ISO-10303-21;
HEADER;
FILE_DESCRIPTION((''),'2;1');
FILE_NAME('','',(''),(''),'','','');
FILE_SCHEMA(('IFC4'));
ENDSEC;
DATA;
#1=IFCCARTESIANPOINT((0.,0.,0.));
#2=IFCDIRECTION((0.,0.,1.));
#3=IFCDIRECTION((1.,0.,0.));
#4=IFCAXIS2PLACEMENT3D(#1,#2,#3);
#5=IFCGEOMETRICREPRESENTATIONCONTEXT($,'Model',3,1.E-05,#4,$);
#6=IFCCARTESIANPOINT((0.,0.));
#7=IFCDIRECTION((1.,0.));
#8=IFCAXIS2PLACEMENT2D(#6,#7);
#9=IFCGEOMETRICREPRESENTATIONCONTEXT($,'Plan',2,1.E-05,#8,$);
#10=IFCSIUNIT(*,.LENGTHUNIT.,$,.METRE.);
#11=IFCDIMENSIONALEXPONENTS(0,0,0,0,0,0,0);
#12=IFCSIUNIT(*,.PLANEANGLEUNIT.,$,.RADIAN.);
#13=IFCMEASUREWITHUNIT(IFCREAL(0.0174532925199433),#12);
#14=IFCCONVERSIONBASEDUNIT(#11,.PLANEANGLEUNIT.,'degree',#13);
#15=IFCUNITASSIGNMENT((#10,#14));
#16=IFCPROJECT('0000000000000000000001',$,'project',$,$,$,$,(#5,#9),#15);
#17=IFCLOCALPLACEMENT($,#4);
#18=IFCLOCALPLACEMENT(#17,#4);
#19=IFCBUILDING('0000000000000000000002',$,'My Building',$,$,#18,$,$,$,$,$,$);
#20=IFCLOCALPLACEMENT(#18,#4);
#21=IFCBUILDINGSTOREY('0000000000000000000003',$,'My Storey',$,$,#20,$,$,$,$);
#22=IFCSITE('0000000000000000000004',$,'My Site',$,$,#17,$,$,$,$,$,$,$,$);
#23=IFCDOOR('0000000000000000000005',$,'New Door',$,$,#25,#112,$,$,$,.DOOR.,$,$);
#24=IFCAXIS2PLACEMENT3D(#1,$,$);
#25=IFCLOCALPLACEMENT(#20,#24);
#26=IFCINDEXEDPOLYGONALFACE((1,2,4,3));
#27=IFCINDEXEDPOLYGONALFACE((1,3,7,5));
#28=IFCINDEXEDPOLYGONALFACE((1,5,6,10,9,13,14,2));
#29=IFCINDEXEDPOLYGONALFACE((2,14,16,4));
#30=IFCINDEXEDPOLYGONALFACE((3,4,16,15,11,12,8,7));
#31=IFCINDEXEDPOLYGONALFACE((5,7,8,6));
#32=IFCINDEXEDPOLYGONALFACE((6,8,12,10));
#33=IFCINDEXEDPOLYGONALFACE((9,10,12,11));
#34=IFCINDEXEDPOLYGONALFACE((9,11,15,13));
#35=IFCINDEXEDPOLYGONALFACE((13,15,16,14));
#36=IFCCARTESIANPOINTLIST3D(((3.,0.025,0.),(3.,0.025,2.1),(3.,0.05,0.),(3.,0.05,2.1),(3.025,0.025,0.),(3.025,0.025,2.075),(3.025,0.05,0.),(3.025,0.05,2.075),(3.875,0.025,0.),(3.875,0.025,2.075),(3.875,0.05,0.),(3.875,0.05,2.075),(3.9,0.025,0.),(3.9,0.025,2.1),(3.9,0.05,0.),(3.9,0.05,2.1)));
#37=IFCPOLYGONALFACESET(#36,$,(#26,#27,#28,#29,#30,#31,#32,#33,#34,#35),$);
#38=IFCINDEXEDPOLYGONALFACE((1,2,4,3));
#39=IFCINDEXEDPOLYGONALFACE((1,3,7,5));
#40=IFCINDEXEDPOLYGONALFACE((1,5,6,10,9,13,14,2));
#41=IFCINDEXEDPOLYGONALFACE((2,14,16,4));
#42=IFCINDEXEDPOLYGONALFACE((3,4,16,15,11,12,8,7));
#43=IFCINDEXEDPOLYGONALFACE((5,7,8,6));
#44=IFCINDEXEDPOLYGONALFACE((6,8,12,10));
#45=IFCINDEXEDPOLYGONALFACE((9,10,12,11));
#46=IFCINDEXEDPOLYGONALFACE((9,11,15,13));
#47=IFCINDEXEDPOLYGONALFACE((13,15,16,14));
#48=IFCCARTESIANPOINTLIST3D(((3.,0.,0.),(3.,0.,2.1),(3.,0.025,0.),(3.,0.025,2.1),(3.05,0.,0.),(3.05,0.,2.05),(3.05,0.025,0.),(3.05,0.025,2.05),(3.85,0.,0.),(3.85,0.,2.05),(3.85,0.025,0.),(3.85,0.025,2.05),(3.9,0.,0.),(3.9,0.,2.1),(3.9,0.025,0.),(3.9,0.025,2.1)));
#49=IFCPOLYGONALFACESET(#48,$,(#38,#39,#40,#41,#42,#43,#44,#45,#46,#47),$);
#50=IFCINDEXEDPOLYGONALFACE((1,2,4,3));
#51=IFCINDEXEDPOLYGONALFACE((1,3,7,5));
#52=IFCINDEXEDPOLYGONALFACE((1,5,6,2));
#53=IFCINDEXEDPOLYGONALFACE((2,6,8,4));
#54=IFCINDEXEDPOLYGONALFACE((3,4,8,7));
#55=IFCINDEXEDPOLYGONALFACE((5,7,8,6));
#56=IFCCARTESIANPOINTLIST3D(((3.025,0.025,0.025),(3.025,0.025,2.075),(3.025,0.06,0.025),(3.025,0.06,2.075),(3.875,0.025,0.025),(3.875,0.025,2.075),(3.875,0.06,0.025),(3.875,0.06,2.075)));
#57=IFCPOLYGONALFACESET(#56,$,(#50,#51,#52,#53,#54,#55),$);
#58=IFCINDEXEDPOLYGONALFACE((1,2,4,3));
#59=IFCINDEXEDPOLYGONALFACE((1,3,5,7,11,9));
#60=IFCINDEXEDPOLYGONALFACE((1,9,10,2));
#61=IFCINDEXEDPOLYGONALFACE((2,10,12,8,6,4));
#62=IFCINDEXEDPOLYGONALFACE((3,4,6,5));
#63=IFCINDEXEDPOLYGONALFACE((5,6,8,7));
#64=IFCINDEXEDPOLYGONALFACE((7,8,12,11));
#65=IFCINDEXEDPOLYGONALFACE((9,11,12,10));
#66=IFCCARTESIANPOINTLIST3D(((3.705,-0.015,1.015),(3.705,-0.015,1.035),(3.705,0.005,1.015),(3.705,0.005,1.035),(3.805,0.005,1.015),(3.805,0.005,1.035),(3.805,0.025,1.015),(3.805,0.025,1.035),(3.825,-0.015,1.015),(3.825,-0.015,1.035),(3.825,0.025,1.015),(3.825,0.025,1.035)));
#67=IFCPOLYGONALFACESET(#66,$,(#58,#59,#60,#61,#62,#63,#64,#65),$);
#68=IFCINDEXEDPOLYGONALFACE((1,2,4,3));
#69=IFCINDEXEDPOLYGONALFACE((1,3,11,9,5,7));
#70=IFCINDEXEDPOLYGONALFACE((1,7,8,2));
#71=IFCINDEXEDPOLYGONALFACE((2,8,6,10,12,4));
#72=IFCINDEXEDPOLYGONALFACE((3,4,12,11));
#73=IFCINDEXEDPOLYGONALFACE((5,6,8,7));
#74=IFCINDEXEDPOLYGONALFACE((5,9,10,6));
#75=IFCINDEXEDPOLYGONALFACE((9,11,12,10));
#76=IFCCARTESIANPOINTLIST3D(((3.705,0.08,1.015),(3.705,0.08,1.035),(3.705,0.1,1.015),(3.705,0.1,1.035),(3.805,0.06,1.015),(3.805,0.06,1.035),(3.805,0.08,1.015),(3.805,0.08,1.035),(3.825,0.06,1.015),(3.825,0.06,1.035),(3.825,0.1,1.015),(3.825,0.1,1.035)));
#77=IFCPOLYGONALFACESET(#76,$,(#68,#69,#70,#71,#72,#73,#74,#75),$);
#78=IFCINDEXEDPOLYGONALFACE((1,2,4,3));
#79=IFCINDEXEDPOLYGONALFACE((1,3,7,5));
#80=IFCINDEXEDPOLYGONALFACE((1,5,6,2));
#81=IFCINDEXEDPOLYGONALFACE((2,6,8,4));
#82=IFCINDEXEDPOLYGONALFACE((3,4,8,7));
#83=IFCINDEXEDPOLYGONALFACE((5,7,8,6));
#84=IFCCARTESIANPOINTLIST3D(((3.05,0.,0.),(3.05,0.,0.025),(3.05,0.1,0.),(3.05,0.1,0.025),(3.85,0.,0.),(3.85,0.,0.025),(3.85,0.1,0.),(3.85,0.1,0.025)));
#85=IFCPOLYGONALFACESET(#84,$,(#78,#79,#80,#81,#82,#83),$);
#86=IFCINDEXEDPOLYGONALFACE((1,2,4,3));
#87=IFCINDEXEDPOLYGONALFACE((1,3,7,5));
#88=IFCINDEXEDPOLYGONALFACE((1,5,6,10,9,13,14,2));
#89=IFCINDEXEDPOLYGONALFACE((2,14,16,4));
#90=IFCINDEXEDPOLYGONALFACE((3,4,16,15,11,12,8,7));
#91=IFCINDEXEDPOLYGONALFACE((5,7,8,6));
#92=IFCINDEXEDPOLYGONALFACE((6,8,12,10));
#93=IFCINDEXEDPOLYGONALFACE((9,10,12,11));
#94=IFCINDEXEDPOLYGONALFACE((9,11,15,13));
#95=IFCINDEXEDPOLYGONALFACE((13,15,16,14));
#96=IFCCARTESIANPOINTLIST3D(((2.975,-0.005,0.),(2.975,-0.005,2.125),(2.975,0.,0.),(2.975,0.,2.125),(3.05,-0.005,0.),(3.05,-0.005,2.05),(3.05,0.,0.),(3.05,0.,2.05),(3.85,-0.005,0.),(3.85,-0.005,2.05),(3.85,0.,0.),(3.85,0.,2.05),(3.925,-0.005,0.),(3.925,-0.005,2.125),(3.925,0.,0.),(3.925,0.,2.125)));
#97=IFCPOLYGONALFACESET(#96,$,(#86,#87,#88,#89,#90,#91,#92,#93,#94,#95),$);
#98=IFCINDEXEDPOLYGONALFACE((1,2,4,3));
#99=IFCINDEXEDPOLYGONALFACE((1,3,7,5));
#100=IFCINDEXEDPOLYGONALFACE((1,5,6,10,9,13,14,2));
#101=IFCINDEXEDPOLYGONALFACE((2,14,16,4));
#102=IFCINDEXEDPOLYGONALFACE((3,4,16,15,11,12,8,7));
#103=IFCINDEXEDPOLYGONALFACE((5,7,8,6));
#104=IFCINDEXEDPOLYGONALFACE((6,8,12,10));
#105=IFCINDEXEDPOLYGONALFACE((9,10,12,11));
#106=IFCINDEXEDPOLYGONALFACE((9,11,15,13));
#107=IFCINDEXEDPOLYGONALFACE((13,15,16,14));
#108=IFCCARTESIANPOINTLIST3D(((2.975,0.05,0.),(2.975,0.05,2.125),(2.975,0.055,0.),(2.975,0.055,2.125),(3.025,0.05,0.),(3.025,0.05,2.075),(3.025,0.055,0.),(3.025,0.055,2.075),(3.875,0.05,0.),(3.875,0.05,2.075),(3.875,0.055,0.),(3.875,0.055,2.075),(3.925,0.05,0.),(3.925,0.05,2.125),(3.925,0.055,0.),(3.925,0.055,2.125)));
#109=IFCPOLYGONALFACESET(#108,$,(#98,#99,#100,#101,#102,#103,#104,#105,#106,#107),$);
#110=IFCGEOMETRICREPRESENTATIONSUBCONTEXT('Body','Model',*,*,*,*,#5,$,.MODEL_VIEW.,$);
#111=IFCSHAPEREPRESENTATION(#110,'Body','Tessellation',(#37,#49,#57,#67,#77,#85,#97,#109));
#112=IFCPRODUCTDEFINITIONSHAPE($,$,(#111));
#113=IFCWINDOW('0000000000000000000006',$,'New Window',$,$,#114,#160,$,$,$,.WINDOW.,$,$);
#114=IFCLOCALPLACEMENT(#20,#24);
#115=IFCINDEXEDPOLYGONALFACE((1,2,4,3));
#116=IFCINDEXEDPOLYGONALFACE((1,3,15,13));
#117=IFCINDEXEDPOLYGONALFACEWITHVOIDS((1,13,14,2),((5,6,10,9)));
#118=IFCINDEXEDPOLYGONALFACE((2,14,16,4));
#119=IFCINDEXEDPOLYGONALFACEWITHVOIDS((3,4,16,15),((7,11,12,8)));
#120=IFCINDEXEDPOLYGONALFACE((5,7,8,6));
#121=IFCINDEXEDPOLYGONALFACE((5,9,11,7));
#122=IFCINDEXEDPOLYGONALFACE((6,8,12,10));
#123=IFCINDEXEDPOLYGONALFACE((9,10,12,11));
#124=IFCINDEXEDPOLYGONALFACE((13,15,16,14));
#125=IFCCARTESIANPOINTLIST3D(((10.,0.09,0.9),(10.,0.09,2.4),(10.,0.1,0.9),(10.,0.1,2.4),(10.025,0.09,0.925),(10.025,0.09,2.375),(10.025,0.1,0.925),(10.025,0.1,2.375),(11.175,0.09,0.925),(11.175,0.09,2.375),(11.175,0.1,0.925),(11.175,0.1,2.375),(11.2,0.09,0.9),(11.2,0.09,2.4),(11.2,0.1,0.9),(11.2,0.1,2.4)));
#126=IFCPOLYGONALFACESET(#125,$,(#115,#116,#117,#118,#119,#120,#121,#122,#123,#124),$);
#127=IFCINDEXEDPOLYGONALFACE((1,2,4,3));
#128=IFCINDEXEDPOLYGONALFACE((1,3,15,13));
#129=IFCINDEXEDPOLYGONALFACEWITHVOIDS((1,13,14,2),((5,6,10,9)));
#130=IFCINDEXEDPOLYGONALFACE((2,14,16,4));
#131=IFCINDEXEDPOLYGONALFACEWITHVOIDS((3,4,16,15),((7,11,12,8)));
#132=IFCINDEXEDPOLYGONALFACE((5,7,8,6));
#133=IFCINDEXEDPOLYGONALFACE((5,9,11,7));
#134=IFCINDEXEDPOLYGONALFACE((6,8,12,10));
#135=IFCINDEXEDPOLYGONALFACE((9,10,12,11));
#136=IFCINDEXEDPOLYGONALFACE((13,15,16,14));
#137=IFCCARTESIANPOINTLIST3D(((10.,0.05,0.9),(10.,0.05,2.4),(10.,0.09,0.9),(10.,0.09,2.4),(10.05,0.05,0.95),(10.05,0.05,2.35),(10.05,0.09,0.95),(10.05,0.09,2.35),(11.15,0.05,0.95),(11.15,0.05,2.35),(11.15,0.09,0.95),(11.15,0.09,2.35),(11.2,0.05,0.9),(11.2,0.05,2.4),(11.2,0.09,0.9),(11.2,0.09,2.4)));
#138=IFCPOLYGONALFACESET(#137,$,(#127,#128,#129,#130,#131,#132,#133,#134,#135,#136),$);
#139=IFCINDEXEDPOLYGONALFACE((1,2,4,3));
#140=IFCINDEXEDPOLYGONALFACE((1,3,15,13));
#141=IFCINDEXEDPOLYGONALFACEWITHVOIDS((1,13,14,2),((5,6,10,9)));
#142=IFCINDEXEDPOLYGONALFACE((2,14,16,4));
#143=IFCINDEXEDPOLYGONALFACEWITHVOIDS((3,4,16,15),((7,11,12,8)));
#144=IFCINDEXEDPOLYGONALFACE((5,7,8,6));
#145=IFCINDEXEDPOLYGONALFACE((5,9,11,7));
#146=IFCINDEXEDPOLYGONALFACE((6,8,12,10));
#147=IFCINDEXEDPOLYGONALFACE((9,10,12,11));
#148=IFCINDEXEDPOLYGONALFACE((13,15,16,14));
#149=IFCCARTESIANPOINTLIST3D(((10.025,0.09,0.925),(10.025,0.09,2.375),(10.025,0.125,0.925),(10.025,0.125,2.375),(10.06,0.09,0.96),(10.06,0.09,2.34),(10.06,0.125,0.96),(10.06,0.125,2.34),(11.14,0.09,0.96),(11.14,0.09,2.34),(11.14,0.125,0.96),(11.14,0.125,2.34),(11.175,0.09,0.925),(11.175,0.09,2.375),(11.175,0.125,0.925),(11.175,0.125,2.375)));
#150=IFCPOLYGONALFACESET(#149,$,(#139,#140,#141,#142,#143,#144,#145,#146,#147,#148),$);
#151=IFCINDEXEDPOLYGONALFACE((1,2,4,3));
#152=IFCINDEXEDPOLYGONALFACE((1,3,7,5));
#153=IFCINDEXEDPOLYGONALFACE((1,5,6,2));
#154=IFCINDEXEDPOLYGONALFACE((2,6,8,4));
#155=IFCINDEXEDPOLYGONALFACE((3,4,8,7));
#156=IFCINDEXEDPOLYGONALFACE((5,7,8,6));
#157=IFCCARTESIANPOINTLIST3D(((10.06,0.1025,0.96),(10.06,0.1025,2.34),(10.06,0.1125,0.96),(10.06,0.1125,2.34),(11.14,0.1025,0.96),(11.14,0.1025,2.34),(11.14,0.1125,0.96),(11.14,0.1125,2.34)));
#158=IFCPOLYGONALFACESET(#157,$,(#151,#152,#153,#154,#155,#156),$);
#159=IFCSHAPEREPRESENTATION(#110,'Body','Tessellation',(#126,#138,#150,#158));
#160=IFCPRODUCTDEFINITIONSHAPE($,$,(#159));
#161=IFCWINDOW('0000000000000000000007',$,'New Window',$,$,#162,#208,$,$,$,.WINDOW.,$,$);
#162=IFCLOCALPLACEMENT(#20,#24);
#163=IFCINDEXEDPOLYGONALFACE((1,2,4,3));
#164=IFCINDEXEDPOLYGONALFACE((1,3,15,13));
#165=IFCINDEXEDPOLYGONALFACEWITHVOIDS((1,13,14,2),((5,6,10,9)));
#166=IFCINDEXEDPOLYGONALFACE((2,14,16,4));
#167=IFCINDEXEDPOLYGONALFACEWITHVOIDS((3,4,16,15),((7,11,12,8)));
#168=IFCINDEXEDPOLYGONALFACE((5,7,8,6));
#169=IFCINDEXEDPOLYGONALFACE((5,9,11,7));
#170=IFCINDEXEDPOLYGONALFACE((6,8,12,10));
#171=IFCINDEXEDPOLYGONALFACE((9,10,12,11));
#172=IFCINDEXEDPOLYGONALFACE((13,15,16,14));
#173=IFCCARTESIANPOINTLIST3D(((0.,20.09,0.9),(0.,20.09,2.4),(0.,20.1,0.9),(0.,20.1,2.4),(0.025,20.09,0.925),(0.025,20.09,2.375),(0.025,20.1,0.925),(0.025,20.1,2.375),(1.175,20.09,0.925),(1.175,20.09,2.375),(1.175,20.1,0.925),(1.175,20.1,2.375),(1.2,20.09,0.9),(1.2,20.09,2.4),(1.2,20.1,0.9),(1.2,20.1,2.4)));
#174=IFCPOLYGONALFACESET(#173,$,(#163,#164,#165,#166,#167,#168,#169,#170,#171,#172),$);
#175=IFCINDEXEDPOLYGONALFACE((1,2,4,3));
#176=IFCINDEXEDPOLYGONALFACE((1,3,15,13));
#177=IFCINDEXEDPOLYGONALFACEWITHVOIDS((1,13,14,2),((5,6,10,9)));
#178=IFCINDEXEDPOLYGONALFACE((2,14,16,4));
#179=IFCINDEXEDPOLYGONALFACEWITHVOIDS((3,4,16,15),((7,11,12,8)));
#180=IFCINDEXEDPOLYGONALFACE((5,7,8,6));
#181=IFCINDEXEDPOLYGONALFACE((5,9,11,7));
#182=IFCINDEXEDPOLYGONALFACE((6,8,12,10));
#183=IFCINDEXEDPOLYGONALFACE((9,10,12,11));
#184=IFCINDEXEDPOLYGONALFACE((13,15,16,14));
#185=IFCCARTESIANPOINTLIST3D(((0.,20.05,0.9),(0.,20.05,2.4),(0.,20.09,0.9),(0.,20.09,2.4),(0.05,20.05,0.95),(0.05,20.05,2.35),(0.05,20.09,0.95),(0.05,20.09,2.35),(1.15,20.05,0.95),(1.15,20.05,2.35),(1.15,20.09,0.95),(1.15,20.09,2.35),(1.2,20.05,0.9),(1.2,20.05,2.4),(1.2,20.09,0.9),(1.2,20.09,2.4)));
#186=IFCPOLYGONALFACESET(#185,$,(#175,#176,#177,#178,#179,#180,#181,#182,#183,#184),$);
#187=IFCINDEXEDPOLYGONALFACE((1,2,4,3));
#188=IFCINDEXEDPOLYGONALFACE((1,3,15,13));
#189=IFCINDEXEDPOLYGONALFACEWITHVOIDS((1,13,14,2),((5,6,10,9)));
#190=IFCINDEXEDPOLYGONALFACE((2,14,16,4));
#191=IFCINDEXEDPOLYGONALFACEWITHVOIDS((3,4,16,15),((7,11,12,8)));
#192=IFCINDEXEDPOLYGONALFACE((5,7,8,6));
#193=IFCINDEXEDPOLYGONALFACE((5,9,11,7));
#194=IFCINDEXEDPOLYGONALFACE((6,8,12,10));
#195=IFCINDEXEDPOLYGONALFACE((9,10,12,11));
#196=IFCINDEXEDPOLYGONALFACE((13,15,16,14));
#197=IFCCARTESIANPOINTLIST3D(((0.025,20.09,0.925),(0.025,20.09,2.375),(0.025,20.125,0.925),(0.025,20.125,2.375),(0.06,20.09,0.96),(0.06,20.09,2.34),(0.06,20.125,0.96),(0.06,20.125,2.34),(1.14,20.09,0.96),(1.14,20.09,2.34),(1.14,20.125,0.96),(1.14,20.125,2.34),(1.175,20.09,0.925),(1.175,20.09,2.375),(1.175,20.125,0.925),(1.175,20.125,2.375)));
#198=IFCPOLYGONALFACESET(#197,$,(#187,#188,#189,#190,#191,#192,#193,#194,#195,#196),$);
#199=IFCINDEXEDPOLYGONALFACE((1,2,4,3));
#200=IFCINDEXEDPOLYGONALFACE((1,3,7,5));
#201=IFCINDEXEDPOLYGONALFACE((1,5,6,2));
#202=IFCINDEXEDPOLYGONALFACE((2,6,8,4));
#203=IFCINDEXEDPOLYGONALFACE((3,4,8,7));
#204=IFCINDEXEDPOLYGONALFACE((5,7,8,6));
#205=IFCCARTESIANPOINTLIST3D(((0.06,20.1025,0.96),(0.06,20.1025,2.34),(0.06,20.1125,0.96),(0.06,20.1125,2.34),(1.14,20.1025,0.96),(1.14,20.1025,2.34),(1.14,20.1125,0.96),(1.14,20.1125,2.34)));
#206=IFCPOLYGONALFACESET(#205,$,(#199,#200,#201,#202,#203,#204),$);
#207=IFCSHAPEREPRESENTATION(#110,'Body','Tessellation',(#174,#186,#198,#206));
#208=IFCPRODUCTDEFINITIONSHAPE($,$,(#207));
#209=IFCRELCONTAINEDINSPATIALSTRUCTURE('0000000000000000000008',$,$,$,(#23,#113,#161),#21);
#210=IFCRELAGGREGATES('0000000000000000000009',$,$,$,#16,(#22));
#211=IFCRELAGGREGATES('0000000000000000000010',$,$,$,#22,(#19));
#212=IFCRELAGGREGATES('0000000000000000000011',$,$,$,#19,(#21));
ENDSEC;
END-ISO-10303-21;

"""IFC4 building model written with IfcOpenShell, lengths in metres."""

from ifc_helpers import new_model, entity, si_unit, converted_unit, frame, origin_with_axes, origin_2d_with_axis, place, context, subcontext, project, spatial, line, indexed_curve, outline, extrude, element, save


model = new_model("IFC4")

# Units and contexts
model_context = context("Model", 3, precision=1e-05, world=origin_with_axes())
plan_context = context("Plan", 2, precision=1e-05, world=origin_2d_with_axis())
body_context = subcontext(model_context, "Body", "Model", "MODEL_VIEW")
ifc_project = project(units=[si_unit("LENGTHUNIT", "METRE"), converted_unit("PLANEANGLEUNIT", "degree", entity("IfcReal", 0.0174532925199433), si_unit("PLANEANGLEUNIT", "RADIAN"), dimensions=[0, 0, 0, 0, 0, 0, 0])], contexts=[model_context, plan_context])

# Site, building, storey
site_placement = place(None, origin_with_axes())
site = spatial("IfcSite", under=ifc_project, at=site_placement, Name="My Site")
building_placement = place(site_placement, origin_with_axes())
building = spatial("IfcBuilding", under=site, at=building_placement, Name="My Building")
storey_placement = place(building_placement, origin_with_axes())
storey = spatial("IfcBuildingStorey", under=building, at=storey_placement, Name="My Storey")

# Door
door_placement = place(storey_placement, frame((3.0, 0.0, 0.0), z_axis=(0.0, 0.0, 1.0), x_axis=(1.0, 0.0, 0.0)))
element("IfcDoor", 1, at=door_placement, inside=storey, Name="New Door", PredefinedType="DOOR", context=body_context, shape_type="SweptSolid", body=[
    extrude(outline(indexed_curve([(0.0, 0.0), (0.0, 2.1), (0.9, 2.1), (0.9, 0.0), (0.875, 0.0), (0.875, 2.075), (0.025, 2.075), (0.025, 0.0)], segments=[line(1, 2, 3, 4, 5, 6, 7, 8, 1)])), frame((0.0, 0.025, 0.0), z_axis=(0.0, -1.0, 0.0), x_axis=(1.0, 0.0, 0.0)), (0.0, 0.0, -1.0), 0.025),
    extrude(outline(indexed_curve([(0.0, 0.0), (0.0, 2.1), (0.9, 2.1), (0.9, 0.0), (0.85, 0.0), (0.85, 2.05), (0.05, 2.05), (0.05, 0.0)], segments=[line(1, 2, 3, 4, 5, 6, 7, 8, 1)])), frame((0.0, 0.0, 0.0), z_axis=(0.0, -1.0, 0.0), x_axis=(1.0, 0.0, 0.0)), (0.0, 0.0, -1.0), 0.025),
    extrude(outline(indexed_curve([(0.0, 0.0), (0.85, 0.0), (0.85, 0.035), (0.0, 0.035)], segments=[line(1, 2, 3, 4, 1)])), frame((0.025, 0.025, 0.025), z_axis=(0.0, 0.0, 1.0), x_axis=(1.0, 0.0, 0.0)), (0.0, 0.0, 1.0), 2.05),
    extrude(outline(indexed_curve([(0.0, 0.0), (0.0, -0.04), (-0.12, -0.04), (-0.12, -0.02), (-0.02, -0.02), (-0.02, 0.0)], segments=[line(1, 2, 3, 4, 5, 6, 1)])), frame((0.825, 0.025, 1.015), z_axis=(0.0, 0.0, 1.0), x_axis=(1.0, 0.0, 0.0)), (0.0, 0.0, 1.0), 0.02),
    extrude(outline(indexed_curve([(0.0, 0.0), (0.0, 0.04), (-0.12, 0.04), (-0.12, 0.02), (-0.02, 0.02), (-0.02, 0.0)], segments=[line(1, 2, 3, 4, 5, 6, 1)])), frame((0.825, 0.06, 1.015), z_axis=(0.0, 0.0, 1.0), x_axis=(1.0, 0.0, 0.0)), (0.0, 0.0, 1.0), 0.02),
    extrude(outline(indexed_curve([(0.0, 0.0), (0.8, 0.0), (0.8, 0.1), (0.0, 0.1)], segments=[line(1, 2, 3, 4, 1)])), frame((0.05, 0.0, 0.0), z_axis=(0.0, 0.0, 1.0), x_axis=(1.0, 0.0, 0.0)), (0.0, 0.0, 1.0), 0.025),
    extrude(outline(indexed_curve([(0.0, 0.0), (0.0, 2.125), (0.95, 2.125), (0.95, 0.0), (0.875, 0.0), (0.875, 2.05), (0.075, 2.05), (0.075, 0.0)], segments=[line(1, 2, 3, 4, 5, 6, 7, 8, 1)])), frame((-0.025, -0.005, 0.0), z_axis=(0.0, -1.0, 0.0), x_axis=(1.0, 0.0, 0.0)), (0.0, 0.0, -1.0), 0.005),
    extrude(outline(indexed_curve([(0.0, 0.0), (0.0, 2.125), (0.95, 2.125), (0.95, 0.0), (0.9, 0.0), (0.9, 2.075), (0.05, 2.075), (0.05, 0.0)], segments=[line(1, 2, 3, 4, 5, 6, 7, 8, 1)])), frame((-0.025, 0.05, 0.0), z_axis=(0.0, -1.0, 0.0), x_axis=(1.0, 0.0, 0.0)), (0.0, 0.0, -1.0), 0.005),
])

# Windows
for number, where, z_axis, x_axis, name in (
    (2, (10.0, 0.0, 0.9), (0.0, 0.0, 1.0), (1.0, 0.0, 0.0), "New Window"),
    (3, (0.0, 20.0, 0.9), (0.0, 0.0, 1.0), (1.0, 0.0, 0.0), "New Window"),
):
    element("IfcWindow", number, at=place(storey_placement, frame(where, z_axis=z_axis, x_axis=x_axis)), inside=storey, Name=name, PredefinedType="WINDOW", context=body_context, shape_type="SweptSolid", body=[
        extrude(outline(indexed_curve([(0.0, 0.0), (1.2, 0.0), (1.2, 1.5), (0.0, 1.5)], segments=[line(1, 2, 3, 4, 1)]), holes=[indexed_curve([(0.025, 0.025), (1.175, 0.025), (1.175, 1.475), (0.025, 1.475)], segments=[line(1, 2, 3, 4, 1)])]), frame((0.0, 0.09, 0.0), z_axis=(0.0, -1.0, 0.0), x_axis=(1.0, 0.0, 0.0)), (0.0, 0.0, -1.0), 0.01),
        extrude(outline(indexed_curve([(0.0, 0.0), (1.2, 0.0), (1.2, 1.5), (0.0, 1.5)], segments=[line(1, 2, 3, 4, 1)]), holes=[indexed_curve([(0.05, 0.05), (1.15, 0.05), (1.15, 1.45), (0.05, 1.45)], segments=[line(1, 2, 3, 4, 1)])]), frame((0.0, 0.05, 0.0), z_axis=(0.0, -1.0, 0.0), x_axis=(1.0, 0.0, 0.0)), (0.0, 0.0, -1.0), 0.04),
        extrude(outline(indexed_curve([(0.0, 0.0), (1.15, 0.0), (1.15, 1.45), (0.0, 1.45)], segments=[line(1, 2, 3, 4, 1)]), holes=[indexed_curve([(0.035, 0.035), (1.115, 0.035), (1.115, 1.415), (0.035, 1.415)], segments=[line(1, 2, 3, 4, 1)])]), frame((0.025, 0.09, 0.025), z_axis=(0.0, -1.0, 0.0), x_axis=(1.0, 0.0, 0.0)), (0.0, 0.0, -1.0), 0.035),
        extrude(outline(indexed_curve([(0.035, 0.035), (1.115, 0.035), (1.115, 1.415), (0.035, 1.415)], segments=[line(1, 2, 3, 4, 1)])), frame((0.025, 0.1025, 0.025), z_axis=(0.0, -1.0, 0.0), x_axis=(1.0, 0.0, 0.0)), (0.0, 0.0, -1.0), 0.01),
    ])

save(model, "model.ifc")
